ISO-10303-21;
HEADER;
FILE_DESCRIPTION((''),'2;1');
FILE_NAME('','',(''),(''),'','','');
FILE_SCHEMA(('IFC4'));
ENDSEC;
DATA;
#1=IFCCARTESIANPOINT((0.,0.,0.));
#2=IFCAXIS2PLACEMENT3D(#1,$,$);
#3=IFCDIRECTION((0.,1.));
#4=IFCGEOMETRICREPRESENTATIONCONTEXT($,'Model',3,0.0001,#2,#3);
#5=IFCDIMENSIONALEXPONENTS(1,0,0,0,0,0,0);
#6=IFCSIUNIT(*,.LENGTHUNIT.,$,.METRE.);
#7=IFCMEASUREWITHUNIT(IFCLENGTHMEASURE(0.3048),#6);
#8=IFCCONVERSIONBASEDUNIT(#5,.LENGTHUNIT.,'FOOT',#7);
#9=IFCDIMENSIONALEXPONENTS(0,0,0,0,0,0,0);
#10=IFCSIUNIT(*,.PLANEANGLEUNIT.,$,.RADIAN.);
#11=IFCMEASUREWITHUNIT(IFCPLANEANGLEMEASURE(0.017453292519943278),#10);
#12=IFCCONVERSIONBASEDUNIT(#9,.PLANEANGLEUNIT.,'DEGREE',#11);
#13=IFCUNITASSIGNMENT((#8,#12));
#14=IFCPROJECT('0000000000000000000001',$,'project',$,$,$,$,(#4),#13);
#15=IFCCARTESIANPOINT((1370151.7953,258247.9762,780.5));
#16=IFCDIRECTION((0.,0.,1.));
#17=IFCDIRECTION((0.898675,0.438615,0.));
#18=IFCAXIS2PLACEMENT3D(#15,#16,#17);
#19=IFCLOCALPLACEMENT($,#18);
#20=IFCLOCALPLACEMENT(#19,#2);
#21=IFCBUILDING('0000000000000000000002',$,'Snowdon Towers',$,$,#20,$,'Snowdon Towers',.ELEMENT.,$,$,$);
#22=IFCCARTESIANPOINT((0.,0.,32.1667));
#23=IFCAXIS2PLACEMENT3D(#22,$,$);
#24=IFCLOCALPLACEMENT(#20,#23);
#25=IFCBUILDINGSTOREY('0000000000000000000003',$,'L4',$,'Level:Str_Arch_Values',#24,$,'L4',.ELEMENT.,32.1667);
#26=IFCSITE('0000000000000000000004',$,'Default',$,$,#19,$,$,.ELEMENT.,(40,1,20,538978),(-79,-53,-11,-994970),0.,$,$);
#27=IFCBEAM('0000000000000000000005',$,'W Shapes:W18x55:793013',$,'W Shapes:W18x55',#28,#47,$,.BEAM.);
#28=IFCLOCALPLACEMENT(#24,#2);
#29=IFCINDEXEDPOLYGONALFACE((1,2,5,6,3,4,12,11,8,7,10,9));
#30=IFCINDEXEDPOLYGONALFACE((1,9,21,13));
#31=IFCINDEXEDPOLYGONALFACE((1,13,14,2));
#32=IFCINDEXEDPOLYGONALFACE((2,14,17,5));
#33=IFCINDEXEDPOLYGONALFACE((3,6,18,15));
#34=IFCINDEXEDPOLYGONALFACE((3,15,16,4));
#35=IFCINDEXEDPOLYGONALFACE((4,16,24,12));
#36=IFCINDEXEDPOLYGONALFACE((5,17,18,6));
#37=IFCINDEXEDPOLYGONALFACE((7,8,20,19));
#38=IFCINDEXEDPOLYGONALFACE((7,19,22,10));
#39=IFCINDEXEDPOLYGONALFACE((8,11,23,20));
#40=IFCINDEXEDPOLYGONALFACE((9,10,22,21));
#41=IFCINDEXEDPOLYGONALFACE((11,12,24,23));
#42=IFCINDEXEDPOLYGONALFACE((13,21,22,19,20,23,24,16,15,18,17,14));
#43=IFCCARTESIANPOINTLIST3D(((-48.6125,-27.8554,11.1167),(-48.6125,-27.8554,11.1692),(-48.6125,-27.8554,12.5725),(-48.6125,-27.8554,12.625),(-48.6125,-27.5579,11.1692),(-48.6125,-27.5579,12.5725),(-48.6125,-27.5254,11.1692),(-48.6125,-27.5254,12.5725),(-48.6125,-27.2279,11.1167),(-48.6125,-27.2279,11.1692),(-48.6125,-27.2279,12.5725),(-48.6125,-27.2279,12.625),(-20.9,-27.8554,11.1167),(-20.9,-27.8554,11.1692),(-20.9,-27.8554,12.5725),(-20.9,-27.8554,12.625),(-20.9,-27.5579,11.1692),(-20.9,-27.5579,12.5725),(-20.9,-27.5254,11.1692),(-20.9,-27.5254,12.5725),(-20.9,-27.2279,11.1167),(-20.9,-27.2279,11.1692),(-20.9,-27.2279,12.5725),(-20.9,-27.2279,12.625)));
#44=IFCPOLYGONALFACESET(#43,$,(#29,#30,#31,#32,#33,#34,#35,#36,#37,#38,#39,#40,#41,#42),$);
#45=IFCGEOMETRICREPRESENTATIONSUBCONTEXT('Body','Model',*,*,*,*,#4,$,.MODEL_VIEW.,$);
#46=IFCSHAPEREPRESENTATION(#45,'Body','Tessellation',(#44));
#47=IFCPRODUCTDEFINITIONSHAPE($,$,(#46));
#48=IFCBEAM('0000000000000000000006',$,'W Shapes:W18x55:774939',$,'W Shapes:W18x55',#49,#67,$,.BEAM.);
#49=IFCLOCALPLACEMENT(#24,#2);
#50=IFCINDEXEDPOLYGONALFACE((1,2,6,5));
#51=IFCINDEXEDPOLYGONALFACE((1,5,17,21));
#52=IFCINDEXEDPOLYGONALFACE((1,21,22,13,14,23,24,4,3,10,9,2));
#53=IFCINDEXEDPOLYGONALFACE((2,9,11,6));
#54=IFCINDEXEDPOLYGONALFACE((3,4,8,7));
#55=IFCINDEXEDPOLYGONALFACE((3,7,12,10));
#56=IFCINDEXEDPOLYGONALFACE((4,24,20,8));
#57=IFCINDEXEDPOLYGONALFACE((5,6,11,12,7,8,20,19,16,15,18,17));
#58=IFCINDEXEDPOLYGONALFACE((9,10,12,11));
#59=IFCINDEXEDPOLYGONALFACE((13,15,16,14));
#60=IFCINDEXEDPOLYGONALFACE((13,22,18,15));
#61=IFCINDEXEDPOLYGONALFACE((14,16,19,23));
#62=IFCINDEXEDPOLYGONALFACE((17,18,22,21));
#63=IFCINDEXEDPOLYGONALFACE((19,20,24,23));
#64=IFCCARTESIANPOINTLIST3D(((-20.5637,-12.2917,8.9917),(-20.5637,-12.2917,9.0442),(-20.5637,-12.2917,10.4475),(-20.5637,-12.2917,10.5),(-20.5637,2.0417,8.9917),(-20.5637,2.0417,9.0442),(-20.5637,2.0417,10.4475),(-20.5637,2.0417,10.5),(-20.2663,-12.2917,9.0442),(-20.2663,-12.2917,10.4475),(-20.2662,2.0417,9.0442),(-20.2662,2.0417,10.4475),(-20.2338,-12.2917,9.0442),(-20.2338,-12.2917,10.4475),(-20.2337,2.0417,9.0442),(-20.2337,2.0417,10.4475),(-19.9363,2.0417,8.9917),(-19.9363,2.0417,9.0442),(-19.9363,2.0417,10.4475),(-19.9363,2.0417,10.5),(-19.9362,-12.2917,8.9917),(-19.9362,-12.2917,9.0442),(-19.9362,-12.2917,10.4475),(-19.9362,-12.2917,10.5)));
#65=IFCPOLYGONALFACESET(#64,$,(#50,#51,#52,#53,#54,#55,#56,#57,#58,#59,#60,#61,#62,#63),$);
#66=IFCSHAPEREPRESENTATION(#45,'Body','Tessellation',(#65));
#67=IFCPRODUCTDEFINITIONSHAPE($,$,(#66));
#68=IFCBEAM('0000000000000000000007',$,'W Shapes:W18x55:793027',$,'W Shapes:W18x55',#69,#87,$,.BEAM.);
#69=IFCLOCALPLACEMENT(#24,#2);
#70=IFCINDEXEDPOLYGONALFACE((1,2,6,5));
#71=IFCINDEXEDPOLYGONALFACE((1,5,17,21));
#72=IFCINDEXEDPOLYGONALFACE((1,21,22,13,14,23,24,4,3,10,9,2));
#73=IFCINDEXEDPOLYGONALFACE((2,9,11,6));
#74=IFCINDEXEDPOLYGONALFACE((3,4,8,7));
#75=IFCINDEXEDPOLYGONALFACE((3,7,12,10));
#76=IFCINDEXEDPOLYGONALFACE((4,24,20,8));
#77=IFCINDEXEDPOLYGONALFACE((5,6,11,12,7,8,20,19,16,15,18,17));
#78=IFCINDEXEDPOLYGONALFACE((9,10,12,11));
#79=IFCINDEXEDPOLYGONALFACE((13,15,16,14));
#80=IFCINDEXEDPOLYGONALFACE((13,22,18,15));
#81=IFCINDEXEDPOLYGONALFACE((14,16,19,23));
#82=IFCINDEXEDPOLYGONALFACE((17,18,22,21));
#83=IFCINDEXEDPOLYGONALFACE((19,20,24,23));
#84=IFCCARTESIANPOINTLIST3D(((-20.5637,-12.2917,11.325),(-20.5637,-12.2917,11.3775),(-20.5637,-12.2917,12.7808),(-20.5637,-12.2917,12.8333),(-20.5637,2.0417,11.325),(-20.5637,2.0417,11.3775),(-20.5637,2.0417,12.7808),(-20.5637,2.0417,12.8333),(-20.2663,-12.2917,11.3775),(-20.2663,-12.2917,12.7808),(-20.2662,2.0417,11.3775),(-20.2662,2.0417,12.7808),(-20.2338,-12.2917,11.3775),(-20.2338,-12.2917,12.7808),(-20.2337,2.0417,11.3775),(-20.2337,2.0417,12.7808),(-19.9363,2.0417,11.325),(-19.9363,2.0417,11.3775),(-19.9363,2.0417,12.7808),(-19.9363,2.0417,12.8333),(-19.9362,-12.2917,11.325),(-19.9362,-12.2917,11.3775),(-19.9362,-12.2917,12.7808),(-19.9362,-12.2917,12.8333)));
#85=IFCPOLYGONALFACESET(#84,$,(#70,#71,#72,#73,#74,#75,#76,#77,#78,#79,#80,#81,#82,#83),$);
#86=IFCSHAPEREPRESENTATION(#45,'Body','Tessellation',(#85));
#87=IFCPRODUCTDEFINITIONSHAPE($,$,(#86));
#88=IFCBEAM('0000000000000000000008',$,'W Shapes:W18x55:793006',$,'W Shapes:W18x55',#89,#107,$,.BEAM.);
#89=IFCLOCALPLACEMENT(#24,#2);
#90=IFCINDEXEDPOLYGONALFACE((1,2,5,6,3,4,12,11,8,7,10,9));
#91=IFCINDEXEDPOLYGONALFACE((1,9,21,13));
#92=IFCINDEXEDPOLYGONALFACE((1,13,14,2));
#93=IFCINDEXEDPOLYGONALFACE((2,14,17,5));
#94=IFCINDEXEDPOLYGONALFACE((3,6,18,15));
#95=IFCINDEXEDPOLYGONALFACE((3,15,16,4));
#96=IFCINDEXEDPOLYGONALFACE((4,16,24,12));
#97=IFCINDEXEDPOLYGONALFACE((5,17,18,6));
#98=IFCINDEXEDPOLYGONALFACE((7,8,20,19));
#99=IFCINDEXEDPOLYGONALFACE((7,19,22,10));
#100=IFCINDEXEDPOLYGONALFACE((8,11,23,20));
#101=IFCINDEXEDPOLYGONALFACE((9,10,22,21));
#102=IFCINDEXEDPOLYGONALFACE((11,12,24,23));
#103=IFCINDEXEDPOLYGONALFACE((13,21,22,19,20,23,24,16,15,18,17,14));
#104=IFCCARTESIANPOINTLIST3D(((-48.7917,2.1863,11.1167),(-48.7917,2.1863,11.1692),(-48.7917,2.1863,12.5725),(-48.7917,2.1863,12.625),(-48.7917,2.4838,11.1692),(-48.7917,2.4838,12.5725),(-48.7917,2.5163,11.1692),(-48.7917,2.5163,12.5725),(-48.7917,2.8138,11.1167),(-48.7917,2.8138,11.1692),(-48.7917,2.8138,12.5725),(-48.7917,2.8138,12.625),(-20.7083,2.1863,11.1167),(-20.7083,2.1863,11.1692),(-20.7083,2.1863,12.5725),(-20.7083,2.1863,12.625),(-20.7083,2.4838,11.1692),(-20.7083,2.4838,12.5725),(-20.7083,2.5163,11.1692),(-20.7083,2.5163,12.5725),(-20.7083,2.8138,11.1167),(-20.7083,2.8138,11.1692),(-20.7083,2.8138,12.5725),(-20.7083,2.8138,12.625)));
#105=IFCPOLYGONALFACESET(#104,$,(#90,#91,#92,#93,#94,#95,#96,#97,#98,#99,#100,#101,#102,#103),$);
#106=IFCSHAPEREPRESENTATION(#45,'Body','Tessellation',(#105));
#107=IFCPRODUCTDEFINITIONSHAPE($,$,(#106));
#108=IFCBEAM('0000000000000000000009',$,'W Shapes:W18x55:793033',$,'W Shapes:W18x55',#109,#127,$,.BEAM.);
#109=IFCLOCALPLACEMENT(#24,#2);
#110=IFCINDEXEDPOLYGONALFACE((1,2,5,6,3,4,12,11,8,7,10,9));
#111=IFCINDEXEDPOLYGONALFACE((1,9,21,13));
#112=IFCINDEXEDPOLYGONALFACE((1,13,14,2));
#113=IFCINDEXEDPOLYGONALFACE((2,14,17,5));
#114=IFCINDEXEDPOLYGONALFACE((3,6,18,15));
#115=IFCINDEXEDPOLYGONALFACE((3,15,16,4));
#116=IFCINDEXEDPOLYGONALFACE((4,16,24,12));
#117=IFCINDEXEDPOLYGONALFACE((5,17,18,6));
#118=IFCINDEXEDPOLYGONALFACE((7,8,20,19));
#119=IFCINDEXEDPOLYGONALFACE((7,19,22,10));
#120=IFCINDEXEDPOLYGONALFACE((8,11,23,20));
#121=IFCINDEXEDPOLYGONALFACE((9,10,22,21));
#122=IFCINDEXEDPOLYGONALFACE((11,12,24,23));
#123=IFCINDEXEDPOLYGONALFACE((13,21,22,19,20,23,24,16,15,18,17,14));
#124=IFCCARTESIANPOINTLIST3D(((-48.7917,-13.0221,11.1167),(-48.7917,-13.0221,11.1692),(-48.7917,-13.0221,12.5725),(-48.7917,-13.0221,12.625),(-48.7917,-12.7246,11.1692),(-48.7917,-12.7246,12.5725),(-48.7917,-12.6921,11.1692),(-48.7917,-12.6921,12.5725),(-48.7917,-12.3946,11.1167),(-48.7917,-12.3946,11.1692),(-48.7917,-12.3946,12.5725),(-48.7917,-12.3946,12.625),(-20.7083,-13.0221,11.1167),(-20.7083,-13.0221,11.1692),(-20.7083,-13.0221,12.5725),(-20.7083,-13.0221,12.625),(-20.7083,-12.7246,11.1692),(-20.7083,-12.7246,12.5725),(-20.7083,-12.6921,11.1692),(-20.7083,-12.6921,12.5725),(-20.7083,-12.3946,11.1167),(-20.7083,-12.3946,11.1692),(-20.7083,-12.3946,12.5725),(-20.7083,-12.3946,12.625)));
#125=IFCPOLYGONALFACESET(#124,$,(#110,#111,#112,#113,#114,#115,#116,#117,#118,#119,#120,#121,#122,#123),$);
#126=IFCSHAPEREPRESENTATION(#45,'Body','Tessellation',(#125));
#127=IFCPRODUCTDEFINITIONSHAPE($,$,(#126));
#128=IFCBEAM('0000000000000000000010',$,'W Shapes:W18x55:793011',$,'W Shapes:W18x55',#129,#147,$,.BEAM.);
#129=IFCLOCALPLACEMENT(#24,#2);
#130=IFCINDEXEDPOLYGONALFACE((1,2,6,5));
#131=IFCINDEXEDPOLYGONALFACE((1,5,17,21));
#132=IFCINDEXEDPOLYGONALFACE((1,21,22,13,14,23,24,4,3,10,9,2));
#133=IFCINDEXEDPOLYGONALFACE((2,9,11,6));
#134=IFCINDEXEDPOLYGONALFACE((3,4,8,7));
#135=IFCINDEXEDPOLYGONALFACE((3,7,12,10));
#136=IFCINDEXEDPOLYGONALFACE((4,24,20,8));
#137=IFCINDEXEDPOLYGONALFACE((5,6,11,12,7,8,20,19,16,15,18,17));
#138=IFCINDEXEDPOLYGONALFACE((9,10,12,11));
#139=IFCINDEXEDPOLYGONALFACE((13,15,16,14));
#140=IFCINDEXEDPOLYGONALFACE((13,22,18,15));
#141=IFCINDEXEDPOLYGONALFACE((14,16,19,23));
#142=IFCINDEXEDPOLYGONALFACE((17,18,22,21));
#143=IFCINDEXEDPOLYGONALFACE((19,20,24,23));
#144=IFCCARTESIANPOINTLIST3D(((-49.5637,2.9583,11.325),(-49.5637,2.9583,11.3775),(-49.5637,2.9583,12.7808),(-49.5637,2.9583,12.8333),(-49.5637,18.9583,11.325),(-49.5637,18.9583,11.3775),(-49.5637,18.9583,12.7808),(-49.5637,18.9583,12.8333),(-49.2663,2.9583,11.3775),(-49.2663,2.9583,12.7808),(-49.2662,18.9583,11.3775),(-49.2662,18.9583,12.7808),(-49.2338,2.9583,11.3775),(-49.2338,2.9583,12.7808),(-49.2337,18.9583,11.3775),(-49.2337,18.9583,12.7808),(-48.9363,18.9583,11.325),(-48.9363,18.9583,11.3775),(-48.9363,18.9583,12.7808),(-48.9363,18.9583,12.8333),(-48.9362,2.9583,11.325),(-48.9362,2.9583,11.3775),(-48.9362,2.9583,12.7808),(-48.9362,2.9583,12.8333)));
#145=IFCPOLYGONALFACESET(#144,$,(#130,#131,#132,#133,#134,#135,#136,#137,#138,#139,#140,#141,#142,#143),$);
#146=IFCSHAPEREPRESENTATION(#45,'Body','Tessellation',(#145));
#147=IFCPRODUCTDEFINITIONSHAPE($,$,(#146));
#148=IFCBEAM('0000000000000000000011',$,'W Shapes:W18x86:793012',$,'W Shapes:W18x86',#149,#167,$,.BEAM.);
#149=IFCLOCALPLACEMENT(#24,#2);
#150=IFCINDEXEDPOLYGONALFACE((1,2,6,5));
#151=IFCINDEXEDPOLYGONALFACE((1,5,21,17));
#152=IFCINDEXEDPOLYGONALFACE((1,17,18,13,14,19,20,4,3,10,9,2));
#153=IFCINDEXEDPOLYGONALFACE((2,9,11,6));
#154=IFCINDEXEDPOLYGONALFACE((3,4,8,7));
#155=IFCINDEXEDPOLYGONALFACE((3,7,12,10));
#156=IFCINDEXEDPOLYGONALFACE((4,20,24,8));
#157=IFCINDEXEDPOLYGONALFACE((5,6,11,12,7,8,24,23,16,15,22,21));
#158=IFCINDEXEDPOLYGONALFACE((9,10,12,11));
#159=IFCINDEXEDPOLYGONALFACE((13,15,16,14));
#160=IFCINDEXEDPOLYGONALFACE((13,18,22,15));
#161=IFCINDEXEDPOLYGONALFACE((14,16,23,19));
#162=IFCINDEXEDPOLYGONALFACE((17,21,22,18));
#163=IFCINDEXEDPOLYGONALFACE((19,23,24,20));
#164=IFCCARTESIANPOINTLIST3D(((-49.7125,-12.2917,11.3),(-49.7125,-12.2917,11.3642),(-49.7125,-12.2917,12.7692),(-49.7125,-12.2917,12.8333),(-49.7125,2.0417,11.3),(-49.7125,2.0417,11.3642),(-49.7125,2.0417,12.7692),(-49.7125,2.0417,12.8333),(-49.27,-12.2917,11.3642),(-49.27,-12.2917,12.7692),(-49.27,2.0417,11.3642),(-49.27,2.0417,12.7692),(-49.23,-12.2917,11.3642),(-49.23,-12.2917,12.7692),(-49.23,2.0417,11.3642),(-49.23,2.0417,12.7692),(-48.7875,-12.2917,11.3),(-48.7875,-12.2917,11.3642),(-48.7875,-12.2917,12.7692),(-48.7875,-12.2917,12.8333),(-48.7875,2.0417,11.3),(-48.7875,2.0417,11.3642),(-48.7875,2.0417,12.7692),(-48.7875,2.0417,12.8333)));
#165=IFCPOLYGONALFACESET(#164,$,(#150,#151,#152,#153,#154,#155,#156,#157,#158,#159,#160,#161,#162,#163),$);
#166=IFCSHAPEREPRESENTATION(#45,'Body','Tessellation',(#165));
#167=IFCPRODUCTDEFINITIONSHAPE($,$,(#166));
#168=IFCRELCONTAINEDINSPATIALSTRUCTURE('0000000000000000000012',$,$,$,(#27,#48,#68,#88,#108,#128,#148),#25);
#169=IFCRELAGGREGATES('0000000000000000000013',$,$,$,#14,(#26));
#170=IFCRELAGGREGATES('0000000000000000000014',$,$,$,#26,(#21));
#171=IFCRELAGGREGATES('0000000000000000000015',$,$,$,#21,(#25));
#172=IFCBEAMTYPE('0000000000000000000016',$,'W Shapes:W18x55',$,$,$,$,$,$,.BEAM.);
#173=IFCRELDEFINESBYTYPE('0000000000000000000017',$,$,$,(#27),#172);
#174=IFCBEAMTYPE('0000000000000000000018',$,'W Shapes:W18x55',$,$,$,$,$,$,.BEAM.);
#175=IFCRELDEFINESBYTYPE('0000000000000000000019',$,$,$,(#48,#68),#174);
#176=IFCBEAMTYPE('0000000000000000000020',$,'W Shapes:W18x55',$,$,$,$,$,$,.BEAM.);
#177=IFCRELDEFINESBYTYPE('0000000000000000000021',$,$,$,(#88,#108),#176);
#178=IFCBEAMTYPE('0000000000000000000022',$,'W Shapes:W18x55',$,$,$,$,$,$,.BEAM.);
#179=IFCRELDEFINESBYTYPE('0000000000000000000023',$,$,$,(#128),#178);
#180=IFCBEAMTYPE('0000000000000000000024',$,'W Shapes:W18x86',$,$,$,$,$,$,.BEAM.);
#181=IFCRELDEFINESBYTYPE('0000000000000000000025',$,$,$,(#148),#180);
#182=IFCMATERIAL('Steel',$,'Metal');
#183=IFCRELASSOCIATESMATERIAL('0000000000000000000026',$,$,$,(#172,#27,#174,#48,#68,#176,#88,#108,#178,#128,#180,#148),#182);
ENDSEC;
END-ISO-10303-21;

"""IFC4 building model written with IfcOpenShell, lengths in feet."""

from ifc_helpers import new_model, entity, si_unit, converted_unit, direction, frame, origin, place, context, subcontext, project, spatial, indexed_curve, outline, extrude, source, transform, mapped, material, type_object, type_shapes, element, save


model = new_model("IFC4")

# Units and contexts
model_context = context("Model", 3, precision=0.0001, world=origin(), true_north=direction((0.0, 1.0)))
body_context = subcontext(model_context, "Body", "Model", "MODEL_VIEW")
ifc_project = project(units=[converted_unit("LENGTHUNIT", "FOOT", entity("IfcLengthMeasure", 0.3048), si_unit("LENGTHUNIT", "METRE"), dimensions=[1, 0, 0, 0, 0, 0, 0]), converted_unit("PLANEANGLEUNIT", "DEGREE", entity("IfcPlaneAngleMeasure", 0.017453292519943278), si_unit("PLANEANGLEUNIT", "RADIAN"), dimensions=[0, 0, 0, 0, 0, 0, 0])], contexts=[model_context])

# Site, building, storey
site_placement = place(None, frame((1370151.7953, 258247.9762, 780.5), z_axis=(0.0, 0.0, 1.0), x_axis=(0.898675, 0.438615, 0.0)))
site = spatial("IfcSite", under=ifc_project, at=site_placement, Name="Default", CompositionType="ELEMENT", RefLatitude=(40, 1, 20, 538978), RefLongitude=(-79, -53, -11, -994970), RefElevation=0.0)
building_placement = place(site_placement, origin())
building = spatial("IfcBuilding", under=site, at=building_placement, Name="Snowdon Towers", LongName="Snowdon Towers", CompositionType="ELEMENT")
storey_placement = place(building_placement, frame((0.0, 0.0, 32.1667)))
storey = spatial("IfcBuildingStorey", under=building, at=storey_placement, Name="L4", ObjectType="Level:Str_Arch_Values", LongName="L4", CompositionType="ELEMENT", Elevation=32.1667)

# Beams
ifc_material = material(Name="Steel", Category="Metal")
beam_type_1 = type_object("IfcBeamType", Name="W Shapes:W18x55", PredefinedType="BEAM", material=ifc_material)
shared_shape_1 = source(origin(), body_context, "Body", "SweptSolid", [
    extrude(outline(indexed_curve([(-0.3138, -0.7017), (-0.3138, -0.7542), (0.3138, -0.7542), (0.3138, -0.7017), (0.0162, -0.7017), (0.0162, 0.7017), (0.3138, 0.7017), (0.3138, 0.7542), (-0.3137, 0.7542), (-0.3137, 0.7017), (-0.0163, 0.7017), (-0.0163, -0.7017), (-0.3138, -0.7017)], self_intersect=False)), frame((-13.8625, 0.0, 0.0), z_axis=(-1.0, 0.0, 0.0), x_axis=(0.0, -1.0, 0.0)), (0.0, 0.0, -1.0), 27.7125),
])
type_shapes(beam_type_1, [shared_shape_1])
beam_1_placement = place(storey_placement, frame((-34.75, -27.5417, 11.8708)))
element("IfcBeam", 1, at=beam_1_placement, inside=storey, type_object=beam_type_1, material=ifc_material, Name="W Shapes:W18x55:793013", ObjectType="W Shapes:W18x55", PredefinedType="BEAM", context=body_context, shape_type="MappedRepresentation", body=[
    mapped(shared_shape_1, transform((0.0, 0.0, 0.0), scale=1.0)),
])
beam_type_2 = type_object("IfcBeamType", Name="W Shapes:W18x55", PredefinedType="BEAM", material=ifc_material)
shared_shape_2 = source(origin(), body_context, "Body", "SweptSolid", [
    extrude(outline(indexed_curve([(-0.3138, -0.7017), (-0.3138, -0.7542), (0.3138, -0.7542), (0.3138, -0.7017), (0.0162, -0.7017), (0.0162, 0.7017), (0.3138, 0.7017), (0.3138, 0.7542), (-0.3137, 0.7542), (-0.3137, 0.7017), (-0.0163, 0.7017), (-0.0163, -0.7017), (-0.3138, -0.7017)], self_intersect=False)), frame((-7.1458, 0.0, 0.0), z_axis=(-1.0, 0.0, 0.0), x_axis=(0.0, -1.0, 0.0)), (0.0, 0.0, -1.0), 14.3333),
])
type_shapes(beam_type_2, [shared_shape_2])
for number, where, z_axis, x_axis, name in (
    (2, (-20.25, -5.1042, 9.7458), (0.0, 0.0, 1.0), (0.0, -1.0, 0.0), "W Shapes:W18x55:774939"),
    (3, (-20.25, -5.1042, 12.0792), (0.0, 0.0, 1.0), (0.0, -1.0, 0.0), "W Shapes:W18x55:793027"),
):
    element("IfcBeam", number, at=place(storey_placement, frame(where, z_axis=z_axis, x_axis=x_axis)), inside=storey, type_object=beam_type_2, material=ifc_material, Name=name, ObjectType="W Shapes:W18x55", PredefinedType="BEAM", context=body_context, shape_type="MappedRepresentation", body=[
        mapped(shared_shape_2, transform((0.0, 0.0, 0.0), scale=1.0)),
    ])

# Beams
beam_type_3 = type_object("IfcBeamType", Name="W Shapes:W18x55", PredefinedType="BEAM", material=ifc_material)
shared_shape_3 = source(origin(), body_context, "Body", "SweptSolid", [
    extrude(outline(indexed_curve([(-0.3138, -0.7017), (-0.3138, -0.7542), (0.3138, -0.7542), (0.3138, -0.7017), (0.0162, -0.7017), (0.0162, 0.7017), (0.3138, 0.7017), (0.3138, 0.7542), (-0.3137, 0.7542), (-0.3137, 0.7017), (-0.0163, 0.7017), (-0.0163, -0.7017), (-0.3138, -0.7017)], self_intersect=False)), frame((-14.0417, 0.0, 0.0), z_axis=(-1.0, 0.0, 0.0), x_axis=(0.0, -1.0, 0.0)), (0.0, 0.0, -1.0), 28.0833),
])
type_shapes(beam_type_3, [shared_shape_3])
for number, where, name in (
    (4, (-34.75, 2.5, 11.8708), "W Shapes:W18x55:793006"),
    (5, (-34.75, -12.7083, 11.8708), "W Shapes:W18x55:793033"),
):
    element("IfcBeam", number, at=place(storey_placement, frame(where)), inside=storey, type_object=beam_type_3, material=ifc_material, Name=name, ObjectType="W Shapes:W18x55", PredefinedType="BEAM", context=body_context, shape_type="MappedRepresentation", body=[
        mapped(shared_shape_3, transform((0.0, 0.0, 0.0), scale=1.0)),
    ])

# Beams
beam_type_4 = type_object("IfcBeamType", Name="W Shapes:W18x55", PredefinedType="BEAM", material=ifc_material)
shared_shape_4 = source(origin(), body_context, "Body", "SweptSolid", [
    extrude(outline(indexed_curve([(-0.3138, -0.7017), (-0.3138, -0.7542), (0.3138, -0.7542), (0.3138, -0.7017), (0.0162, -0.7017), (0.0162, 0.7017), (0.3138, 0.7017), (0.3138, 0.7542), (-0.3137, 0.7542), (-0.3137, 0.7017), (-0.0163, 0.7017), (-0.0163, -0.7017), (-0.3138, -0.7017)], self_intersect=False)), frame((-8.1042, 0.0, 0.0), z_axis=(-1.0, 0.0, 0.0), x_axis=(0.0, -1.0, 0.0)), (0.0, 0.0, -1.0), 16.0),
])
type_shapes(beam_type_4, [shared_shape_4])
beam_2_placement = place(storey_placement, frame((-49.25, 10.8542, 12.0792), z_axis=(0.0, 0.0, 1.0), x_axis=(0.0, -1.0, 0.0)))
element("IfcBeam", 6, at=beam_2_placement, inside=storey, type_object=beam_type_4, material=ifc_material, Name="W Shapes:W18x55:793011", ObjectType="W Shapes:W18x55", PredefinedType="BEAM", context=body_context, shape_type="MappedRepresentation", body=[
    mapped(shared_shape_4, transform((0.0, 0.0, 0.0), scale=1.0)),
])
beam_type_5 = type_object("IfcBeamType", Name="W Shapes:W18x86", PredefinedType="BEAM", material=ifc_material)
shared_shape_5 = source(origin(), body_context, "Body", "SweptSolid", [
    extrude(outline(indexed_curve([(-0.4625, -0.7025), (-0.4625, -0.7667), (0.4625, -0.7667), (0.4625, -0.7025), (0.02, -0.7025), (0.02, 0.7025), (0.4625, 0.7025), (0.4625, 0.7667), (-0.4625, 0.7667), (-0.4625, 0.7025), (-0.02, 0.7025), (-0.02, -0.7025), (-0.4625, -0.7025)], self_intersect=False)), frame((-7.1458, 0.0, 0.0), z_axis=(-1.0, 0.0, 0.0), x_axis=(0.0, -1.0, 0.0)), (0.0, 0.0, -1.0), 14.3333),
])
type_shapes(beam_type_5, [shared_shape_5])
beam_3_placement = place(storey_placement, frame((-49.25, -5.1042, 12.0667), z_axis=(0.0, 0.0, 1.0), x_axis=(0.0, -1.0, 0.0)))
element("IfcBeam", 7, at=beam_3_placement, inside=storey, type_object=beam_type_5, material=ifc_material, Name="W Shapes:W18x86:793012", ObjectType="W Shapes:W18x86", PredefinedType="BEAM", context=body_context, shape_type="MappedRepresentation", body=[
    mapped(shared_shape_5, transform((0.0, 0.0, 0.0), scale=1.0)),
])

save(model, "model.ifc")
